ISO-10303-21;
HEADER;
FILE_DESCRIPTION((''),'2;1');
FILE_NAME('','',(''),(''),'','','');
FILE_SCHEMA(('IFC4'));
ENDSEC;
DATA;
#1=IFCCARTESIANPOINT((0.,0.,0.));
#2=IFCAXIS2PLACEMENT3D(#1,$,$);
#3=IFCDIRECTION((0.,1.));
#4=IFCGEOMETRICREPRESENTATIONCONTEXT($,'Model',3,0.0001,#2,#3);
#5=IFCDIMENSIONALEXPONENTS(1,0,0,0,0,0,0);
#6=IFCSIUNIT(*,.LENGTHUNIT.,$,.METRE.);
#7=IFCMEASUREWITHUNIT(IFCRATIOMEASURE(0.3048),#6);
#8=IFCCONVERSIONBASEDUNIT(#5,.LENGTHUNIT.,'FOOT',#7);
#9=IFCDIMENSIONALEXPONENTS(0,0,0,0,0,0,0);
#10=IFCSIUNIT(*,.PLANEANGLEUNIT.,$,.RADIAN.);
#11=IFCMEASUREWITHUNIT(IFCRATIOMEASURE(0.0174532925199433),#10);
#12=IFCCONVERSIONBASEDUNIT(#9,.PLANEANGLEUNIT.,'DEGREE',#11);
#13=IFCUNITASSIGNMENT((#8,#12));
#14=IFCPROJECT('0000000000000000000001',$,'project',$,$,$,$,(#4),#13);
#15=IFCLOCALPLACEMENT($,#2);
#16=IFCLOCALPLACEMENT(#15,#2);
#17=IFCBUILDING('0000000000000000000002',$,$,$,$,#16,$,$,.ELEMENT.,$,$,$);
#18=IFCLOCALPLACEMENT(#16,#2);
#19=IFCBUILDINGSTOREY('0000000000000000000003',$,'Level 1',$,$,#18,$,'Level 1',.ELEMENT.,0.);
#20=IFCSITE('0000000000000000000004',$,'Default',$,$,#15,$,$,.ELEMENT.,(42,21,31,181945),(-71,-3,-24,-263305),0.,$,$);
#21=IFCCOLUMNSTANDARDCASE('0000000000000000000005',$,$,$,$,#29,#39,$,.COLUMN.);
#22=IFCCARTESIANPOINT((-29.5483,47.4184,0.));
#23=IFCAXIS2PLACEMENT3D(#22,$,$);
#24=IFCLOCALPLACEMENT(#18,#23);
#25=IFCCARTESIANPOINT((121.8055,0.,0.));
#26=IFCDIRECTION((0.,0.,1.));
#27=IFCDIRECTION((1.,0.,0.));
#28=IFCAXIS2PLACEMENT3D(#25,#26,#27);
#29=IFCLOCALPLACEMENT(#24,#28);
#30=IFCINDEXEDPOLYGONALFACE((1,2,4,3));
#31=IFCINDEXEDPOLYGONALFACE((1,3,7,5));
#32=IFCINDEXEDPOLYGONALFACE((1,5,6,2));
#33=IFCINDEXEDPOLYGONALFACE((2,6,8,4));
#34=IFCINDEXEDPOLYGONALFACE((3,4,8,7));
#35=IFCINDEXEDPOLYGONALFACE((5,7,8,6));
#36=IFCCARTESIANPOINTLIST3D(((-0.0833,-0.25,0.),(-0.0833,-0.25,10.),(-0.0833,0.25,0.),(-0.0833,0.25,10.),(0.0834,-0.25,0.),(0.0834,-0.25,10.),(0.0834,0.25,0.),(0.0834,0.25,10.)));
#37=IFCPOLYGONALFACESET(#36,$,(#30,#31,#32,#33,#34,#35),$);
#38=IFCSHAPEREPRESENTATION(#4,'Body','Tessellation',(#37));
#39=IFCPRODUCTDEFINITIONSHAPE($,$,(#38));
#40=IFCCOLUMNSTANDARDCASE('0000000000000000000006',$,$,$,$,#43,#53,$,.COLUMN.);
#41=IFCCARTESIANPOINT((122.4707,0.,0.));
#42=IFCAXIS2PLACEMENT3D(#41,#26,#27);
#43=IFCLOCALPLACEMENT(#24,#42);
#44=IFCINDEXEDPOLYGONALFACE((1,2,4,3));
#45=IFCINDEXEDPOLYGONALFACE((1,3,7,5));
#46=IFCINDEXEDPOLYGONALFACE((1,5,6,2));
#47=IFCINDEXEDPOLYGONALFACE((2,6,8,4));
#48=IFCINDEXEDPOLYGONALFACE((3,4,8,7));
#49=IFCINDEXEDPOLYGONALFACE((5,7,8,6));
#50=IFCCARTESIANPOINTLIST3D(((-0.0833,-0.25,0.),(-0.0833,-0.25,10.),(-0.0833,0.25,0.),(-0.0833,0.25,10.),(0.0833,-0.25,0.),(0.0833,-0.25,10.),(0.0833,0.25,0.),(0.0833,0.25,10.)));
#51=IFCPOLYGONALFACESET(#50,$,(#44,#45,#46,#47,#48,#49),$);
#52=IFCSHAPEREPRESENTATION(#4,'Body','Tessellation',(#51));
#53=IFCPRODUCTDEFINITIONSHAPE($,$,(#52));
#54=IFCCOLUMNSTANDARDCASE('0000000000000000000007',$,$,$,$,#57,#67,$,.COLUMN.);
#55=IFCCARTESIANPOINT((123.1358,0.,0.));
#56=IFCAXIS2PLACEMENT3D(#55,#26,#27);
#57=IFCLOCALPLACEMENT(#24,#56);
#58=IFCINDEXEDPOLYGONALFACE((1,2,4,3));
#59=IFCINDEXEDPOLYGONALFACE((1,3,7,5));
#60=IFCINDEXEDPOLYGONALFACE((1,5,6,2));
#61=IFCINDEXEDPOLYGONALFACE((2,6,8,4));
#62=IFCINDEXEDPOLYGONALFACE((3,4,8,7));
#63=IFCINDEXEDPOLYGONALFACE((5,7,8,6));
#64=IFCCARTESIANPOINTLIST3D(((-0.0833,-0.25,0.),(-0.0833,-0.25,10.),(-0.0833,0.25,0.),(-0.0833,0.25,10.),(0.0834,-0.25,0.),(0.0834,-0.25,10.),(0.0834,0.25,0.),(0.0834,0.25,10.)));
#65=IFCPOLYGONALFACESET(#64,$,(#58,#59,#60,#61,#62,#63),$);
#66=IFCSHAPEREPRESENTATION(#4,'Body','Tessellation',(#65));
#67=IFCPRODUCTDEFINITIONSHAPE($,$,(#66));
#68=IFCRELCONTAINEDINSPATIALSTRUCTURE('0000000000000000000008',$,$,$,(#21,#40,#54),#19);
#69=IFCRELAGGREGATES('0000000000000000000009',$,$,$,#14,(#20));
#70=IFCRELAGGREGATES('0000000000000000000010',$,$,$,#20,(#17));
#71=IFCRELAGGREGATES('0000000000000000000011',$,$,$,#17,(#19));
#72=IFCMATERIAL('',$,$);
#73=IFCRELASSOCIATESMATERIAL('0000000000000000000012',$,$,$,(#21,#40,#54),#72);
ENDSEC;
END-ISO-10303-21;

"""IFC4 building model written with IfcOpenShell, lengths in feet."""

from ifc_helpers import new_model, entity, si_unit, converted_unit, direction, frame, origin, place, context, project, spatial, rectangle, extrude, material, element, save


model = new_model("IFC4")

# Units and contexts
model_context = context("Model", 3, precision=0.0001, world=origin(), true_north=direction((0.0, 1.0)))
ifc_project = project(units=[converted_unit("LENGTHUNIT", "FOOT", entity("IfcRatioMeasure", 0.3048), si_unit("LENGTHUNIT", "METRE"), dimensions=[1, 0, 0, 0, 0, 0, 0]), converted_unit("PLANEANGLEUNIT", "DEGREE", entity("IfcRatioMeasure", 0.0174532925199433), si_unit("PLANEANGLEUNIT", "RADIAN"), dimensions=[0, 0, 0, 0, 0, 0, 0])], contexts=[model_context])

# Site, building, storey
site_placement = place(None, origin())
site = spatial("IfcSite", under=ifc_project, at=site_placement, Name="Default", CompositionType="ELEMENT", RefLatitude=(42, 21, 31, 181945), RefLongitude=(-71, -3, -24, -263305), RefElevation=0.0)
building_placement = place(site_placement, origin())
building = spatial("IfcBuilding", under=site, at=building_placement, CompositionType="ELEMENT")
storey_placement = place(building_placement, origin())
storey = spatial("IfcBuildingStorey", under=building, at=storey_placement, Name="Level 1", LongName="Level 1", CompositionType="ELEMENT", Elevation=0.0)

# Columns
ifc_material = material(Name="")
placement = place(storey_placement, frame((-29.5483, 47.4184, 0.0)))
for number, where, z_axis, x_axis in (
    (1, (121.8055, 0.0, 0.0), (0.0, 0.0, 1.0), (1.0, 0.0, 0.0)),
    (2, (122.4707, 0.0, 0.0), (0.0, 0.0, 1.0), (1.0, 0.0, 0.0)),
    (3, (123.1358, 0.0, 0.0), (0.0, 0.0, 1.0), (1.0, 0.0, 0.0)),
):
    element("IfcColumnStandardCase", number, at=place(placement, frame(where, z_axis=z_axis, x_axis=x_axis)), inside=storey, material=ifc_material, PredefinedType="COLUMN", context=model_context, shape_type="SweptSolid", body=[
        extrude(rectangle(XDim=0.1667, YDim=0.5), origin(), (0.0, 0.0, 1.0), 10.0),
    ])

save(model, "model.ifc")
